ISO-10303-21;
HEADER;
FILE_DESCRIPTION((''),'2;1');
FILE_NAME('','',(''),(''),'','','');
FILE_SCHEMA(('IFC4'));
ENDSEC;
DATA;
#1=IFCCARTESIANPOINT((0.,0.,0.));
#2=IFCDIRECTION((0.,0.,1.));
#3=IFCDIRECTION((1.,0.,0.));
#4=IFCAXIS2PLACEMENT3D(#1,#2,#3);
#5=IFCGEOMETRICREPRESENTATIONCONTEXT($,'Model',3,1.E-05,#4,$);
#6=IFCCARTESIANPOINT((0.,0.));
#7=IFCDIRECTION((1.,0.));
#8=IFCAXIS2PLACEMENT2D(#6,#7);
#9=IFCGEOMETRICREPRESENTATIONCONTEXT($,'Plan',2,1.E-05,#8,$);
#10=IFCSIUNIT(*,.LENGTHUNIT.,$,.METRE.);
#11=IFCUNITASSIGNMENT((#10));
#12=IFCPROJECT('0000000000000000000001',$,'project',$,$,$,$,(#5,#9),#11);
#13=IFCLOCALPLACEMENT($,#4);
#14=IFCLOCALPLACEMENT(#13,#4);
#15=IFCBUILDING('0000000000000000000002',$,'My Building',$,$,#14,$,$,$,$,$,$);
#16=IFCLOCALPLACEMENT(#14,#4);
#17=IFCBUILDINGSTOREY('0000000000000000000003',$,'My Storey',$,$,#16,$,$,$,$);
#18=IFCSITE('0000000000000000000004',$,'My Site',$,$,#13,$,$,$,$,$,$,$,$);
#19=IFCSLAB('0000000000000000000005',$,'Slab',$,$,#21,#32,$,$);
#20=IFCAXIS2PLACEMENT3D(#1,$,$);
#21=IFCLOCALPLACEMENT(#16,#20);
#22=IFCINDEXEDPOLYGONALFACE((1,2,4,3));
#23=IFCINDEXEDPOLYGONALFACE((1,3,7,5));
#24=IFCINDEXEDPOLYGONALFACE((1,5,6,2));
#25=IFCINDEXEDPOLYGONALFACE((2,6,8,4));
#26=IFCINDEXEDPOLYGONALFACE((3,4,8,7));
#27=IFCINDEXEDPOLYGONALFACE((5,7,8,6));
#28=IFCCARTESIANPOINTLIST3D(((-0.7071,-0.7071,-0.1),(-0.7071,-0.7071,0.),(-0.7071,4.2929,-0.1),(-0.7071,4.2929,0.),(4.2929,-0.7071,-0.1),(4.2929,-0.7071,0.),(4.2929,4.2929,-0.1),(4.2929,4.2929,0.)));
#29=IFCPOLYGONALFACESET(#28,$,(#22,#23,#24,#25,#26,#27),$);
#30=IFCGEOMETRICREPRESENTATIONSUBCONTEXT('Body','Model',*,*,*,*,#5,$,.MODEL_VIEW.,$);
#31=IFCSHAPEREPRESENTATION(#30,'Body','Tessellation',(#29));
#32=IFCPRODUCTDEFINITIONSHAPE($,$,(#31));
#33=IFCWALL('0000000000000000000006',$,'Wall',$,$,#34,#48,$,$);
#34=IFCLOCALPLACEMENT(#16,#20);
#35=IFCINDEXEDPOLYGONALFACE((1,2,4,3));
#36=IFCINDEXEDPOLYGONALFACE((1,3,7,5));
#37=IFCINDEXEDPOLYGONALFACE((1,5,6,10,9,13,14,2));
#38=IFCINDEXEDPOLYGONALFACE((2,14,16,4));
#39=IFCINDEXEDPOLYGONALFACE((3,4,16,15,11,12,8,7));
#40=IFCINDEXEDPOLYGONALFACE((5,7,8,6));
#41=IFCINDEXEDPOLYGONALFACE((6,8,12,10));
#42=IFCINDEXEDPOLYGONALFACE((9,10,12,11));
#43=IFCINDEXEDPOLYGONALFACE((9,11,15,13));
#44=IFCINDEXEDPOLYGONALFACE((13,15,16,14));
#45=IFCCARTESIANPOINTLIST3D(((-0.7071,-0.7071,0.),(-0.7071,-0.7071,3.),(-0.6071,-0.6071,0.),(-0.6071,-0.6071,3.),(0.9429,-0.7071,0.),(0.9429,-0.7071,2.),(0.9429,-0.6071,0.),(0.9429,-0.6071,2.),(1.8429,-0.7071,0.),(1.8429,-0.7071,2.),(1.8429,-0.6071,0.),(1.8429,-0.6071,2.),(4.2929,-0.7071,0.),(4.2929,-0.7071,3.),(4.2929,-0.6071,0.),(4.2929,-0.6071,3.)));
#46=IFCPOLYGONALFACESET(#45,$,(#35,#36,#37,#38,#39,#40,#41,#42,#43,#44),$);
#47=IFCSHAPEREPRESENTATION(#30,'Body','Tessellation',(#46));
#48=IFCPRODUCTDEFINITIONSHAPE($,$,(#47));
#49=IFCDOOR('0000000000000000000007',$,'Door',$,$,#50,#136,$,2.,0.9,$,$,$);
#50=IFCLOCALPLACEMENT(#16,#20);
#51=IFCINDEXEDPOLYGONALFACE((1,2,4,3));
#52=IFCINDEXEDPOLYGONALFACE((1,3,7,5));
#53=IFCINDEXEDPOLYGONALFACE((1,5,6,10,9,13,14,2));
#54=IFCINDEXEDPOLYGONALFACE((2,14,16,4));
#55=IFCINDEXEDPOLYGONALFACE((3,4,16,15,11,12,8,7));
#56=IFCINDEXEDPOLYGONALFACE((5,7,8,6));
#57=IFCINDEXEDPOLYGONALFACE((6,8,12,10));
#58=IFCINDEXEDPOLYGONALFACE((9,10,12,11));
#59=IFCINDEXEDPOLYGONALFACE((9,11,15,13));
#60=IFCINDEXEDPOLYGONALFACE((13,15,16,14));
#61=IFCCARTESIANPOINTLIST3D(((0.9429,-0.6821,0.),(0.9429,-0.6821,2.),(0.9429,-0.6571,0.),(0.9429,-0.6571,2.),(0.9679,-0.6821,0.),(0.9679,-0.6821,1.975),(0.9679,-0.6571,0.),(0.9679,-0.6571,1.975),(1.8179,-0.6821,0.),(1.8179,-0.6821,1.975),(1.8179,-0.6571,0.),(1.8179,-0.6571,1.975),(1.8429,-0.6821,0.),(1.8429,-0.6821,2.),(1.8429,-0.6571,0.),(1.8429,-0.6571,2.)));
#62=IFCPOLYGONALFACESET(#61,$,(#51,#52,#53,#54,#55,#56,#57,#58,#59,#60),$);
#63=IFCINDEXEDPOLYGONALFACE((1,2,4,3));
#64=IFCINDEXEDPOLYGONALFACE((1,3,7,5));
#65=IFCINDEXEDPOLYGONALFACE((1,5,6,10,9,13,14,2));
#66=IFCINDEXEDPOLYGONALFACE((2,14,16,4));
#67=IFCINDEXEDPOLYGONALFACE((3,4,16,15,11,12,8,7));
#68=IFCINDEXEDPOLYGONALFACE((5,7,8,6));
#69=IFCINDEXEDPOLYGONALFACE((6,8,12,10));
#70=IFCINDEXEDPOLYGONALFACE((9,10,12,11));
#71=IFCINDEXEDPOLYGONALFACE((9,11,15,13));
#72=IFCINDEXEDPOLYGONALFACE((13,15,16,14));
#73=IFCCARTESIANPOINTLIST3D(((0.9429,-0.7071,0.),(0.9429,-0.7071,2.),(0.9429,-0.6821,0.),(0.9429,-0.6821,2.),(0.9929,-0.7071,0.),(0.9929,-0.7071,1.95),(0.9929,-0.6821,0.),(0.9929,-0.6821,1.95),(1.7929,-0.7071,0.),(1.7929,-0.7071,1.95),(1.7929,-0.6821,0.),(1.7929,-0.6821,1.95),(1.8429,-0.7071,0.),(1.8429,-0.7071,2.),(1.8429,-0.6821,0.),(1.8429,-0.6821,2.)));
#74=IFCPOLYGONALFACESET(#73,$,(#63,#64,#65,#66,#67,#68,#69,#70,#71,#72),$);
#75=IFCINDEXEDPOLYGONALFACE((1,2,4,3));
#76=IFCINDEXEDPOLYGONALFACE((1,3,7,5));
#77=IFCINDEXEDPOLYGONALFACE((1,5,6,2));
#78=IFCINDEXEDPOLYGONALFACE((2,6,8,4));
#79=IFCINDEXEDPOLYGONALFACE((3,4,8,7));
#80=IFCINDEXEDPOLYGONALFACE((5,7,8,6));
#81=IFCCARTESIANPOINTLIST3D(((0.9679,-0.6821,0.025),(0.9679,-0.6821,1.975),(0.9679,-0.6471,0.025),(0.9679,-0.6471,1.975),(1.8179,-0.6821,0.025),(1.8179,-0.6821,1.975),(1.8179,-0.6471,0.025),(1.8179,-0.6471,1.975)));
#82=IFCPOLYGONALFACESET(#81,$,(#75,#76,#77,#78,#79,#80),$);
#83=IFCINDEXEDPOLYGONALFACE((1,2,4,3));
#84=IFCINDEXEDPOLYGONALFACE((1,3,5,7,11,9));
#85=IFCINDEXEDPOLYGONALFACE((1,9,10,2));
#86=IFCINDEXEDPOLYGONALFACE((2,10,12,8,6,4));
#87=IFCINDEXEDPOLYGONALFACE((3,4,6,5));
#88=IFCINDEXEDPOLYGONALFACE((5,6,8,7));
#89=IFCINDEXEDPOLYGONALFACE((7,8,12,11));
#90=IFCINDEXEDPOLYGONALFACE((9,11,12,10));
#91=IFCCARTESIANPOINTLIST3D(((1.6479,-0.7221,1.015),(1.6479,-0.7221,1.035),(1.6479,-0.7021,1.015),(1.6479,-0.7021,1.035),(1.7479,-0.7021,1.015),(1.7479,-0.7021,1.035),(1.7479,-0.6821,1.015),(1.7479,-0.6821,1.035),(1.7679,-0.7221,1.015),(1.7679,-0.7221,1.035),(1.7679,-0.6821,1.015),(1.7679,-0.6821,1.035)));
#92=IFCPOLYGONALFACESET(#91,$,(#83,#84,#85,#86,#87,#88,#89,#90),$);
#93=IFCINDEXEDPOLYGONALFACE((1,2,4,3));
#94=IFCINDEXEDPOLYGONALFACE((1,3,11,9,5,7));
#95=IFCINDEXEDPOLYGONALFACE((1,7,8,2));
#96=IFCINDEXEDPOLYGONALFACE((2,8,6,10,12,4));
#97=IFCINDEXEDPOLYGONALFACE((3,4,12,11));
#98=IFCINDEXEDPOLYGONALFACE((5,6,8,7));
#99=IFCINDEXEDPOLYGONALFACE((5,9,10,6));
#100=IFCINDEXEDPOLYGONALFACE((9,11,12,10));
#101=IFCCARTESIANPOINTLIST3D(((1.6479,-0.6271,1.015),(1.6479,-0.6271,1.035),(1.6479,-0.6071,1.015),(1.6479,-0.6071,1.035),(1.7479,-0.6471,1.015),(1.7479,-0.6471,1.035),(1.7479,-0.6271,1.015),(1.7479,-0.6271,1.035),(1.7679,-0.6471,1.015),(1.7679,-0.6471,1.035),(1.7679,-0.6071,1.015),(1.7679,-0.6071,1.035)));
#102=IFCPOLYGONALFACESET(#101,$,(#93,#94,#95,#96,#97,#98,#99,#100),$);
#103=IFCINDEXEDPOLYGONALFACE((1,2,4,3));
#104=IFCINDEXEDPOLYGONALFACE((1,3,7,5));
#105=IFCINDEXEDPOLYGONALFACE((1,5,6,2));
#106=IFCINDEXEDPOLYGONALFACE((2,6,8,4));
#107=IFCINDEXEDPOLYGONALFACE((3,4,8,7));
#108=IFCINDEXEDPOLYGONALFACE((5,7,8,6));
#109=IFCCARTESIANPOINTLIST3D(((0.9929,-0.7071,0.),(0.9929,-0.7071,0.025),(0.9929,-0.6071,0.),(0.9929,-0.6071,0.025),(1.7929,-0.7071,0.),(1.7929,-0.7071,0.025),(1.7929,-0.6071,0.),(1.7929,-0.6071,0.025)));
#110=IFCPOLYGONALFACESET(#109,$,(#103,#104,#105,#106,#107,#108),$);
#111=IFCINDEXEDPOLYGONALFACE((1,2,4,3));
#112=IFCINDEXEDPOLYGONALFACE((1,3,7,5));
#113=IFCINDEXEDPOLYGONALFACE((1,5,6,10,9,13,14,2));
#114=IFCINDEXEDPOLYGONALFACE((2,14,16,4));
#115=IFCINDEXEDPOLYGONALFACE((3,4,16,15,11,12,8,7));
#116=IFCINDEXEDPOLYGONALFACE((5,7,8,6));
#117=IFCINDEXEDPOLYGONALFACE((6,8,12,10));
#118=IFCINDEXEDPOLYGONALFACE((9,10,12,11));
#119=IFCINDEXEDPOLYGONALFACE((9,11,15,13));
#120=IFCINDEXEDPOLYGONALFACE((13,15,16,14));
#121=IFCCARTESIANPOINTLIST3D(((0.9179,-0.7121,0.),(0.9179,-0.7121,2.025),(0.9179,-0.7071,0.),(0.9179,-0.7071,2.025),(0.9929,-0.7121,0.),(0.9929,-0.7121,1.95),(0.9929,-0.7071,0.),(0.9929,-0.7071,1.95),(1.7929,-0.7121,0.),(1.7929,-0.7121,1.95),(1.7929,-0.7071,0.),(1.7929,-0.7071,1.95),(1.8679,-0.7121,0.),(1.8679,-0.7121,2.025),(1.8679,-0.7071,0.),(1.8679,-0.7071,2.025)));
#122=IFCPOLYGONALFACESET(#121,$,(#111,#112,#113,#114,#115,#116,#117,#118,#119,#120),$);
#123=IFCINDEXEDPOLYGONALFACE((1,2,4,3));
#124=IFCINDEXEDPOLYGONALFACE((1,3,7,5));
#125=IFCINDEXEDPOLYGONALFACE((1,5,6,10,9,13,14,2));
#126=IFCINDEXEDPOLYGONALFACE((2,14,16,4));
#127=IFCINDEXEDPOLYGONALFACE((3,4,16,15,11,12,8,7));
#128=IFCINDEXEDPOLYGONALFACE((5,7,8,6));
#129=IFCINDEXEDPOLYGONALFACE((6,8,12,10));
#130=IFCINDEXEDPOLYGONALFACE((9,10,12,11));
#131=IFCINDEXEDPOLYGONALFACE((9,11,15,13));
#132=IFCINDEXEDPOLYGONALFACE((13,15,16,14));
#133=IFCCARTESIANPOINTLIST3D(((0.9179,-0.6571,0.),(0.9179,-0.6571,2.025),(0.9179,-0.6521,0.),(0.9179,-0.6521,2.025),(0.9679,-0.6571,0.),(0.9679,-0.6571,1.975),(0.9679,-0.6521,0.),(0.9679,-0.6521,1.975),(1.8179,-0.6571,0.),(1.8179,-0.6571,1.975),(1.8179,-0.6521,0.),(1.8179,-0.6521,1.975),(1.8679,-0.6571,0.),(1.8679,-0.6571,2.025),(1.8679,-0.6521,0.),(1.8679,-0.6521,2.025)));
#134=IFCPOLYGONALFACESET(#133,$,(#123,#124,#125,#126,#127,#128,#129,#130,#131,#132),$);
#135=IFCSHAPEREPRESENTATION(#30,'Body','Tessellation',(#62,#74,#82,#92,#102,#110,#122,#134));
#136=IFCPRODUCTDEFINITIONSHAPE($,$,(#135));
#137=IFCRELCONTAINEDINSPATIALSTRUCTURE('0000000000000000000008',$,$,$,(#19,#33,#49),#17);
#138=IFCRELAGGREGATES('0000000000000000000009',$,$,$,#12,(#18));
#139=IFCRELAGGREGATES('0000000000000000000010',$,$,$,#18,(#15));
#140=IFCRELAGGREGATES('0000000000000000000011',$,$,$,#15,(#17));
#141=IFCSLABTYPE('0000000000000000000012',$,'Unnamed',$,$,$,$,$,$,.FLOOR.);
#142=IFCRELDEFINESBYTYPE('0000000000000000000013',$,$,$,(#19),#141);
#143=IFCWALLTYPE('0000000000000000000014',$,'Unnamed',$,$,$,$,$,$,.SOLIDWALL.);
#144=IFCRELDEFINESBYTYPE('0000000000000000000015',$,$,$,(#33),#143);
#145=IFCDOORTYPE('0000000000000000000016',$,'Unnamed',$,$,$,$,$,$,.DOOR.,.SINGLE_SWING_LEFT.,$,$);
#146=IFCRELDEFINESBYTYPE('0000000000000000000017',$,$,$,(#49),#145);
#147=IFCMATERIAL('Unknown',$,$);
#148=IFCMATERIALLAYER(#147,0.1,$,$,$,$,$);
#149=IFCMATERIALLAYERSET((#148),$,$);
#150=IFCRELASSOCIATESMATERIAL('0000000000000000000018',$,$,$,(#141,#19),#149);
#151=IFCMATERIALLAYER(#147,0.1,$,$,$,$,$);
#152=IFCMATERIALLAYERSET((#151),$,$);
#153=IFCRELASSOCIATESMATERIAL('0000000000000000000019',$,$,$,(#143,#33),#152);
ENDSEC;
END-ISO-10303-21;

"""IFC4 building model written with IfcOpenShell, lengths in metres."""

from ifc_helpers import new_model, entity, si_unit, frame, origin_with_axes, origin_2d_with_axis, place, context, subcontext, project, spatial, line, indexed_curve, outline, extrude, shape, source, transform, mapped, material, layer, layer_set, layer_usage, type_object, type_shapes, element, fill, save


model = new_model("IFC4")

# Units and contexts
model_context = context("Model", 3, precision=1e-05, world=origin_with_axes())
plan_context = context("Plan", 2, precision=1e-05, world=origin_2d_with_axis())
body_context_1 = subcontext(model_context, "Body", "Model", "MODEL_VIEW")
body_context_2 = subcontext(plan_context, "Body", "Plan", "PLAN_VIEW")
ifc_project = project(units=[si_unit("LENGTHUNIT", "METRE")], contexts=[model_context, plan_context])

# Site, building, storey
site_placement = place(None, origin_with_axes())
site = spatial("IfcSite", under=ifc_project, at=site_placement, Name="My Site")
building_placement = place(site_placement, origin_with_axes())
building = spatial("IfcBuilding", under=site, at=building_placement, Name="My Building")
storey_placement = place(building_placement, origin_with_axes())
storey = spatial("IfcBuildingStorey", under=building, at=storey_placement, Name="My Storey")

# Slab
ifc_material = material(Name="Unknown")
ifc_layer_1 = layer(ifc_material, 0.1)
ifc_layer_set_1 = layer_set([ifc_layer_1])
ifc_layer_usage_1 = layer_usage(ifc_layer_set_1, "AXIS3", "POSITIVE", -0.1)
slab_type = type_object("IfcSlabType", Name="Unnamed", PredefinedType="FLOOR", material=ifc_layer_set_1)
slab_placement = place(storey_placement, frame((-0.7071, -0.7071, 0.0), z_axis=(0.0, 0.0, 1.0), x_axis=(1.0, 0.0, 0.0)))
element("IfcSlab", 1, at=slab_placement, inside=storey, type_object=slab_type, material=ifc_layer_usage_1, Name="Slab", context=body_context_1, shape_type="SweptSolid", body=[
    extrude(outline(indexed_curve([(0.0, 0.0), (5.0, 0.0), (5.0, 5.0), (0.0, 5.0), (0.0, 0.0)])), frame((0.0, 0.0, -0.1), z_axis=(0.0, 0.0, 1.0), x_axis=(1.0, 0.0, 0.0)), (0.0, 0.0, 1.0), 0.1),
])

# Wall, opening, door
ifc_layer_2 = layer(ifc_material, 0.1)
ifc_layer_set_2 = layer_set([ifc_layer_2])
ifc_layer_usage_2 = layer_usage(ifc_layer_set_2, "AXIS2", "POSITIVE", 0.0)
wall_type = type_object("IfcWallType", Name="Unnamed", PredefinedType="SOLIDWALL", material=ifc_layer_set_2)
wall_1_placement = place(storey_placement, frame((-0.7071, -0.7071, 0.0), z_axis=(0.0, 0.0, 1.0), x_axis=(1.0, 0.0, 0.0)))
wall_1 = element("IfcWall", 2, at=wall_1_placement, inside=storey, type_object=wall_type, material=ifc_layer_usage_2, Name="Wall", context=body_context_1, shape_type="SweptSolid", body=[
    extrude(outline(indexed_curve([(0.0, 0.0), (0.1, 0.1), (5.0, 0.1), (5.0, 0.0)], segments=[line(1, 2, 3, 4, 1)])), origin_with_axes(), (0.0, 0.0, 1.0), 3.0),
])
shared_shape_1 = source(origin_with_axes(), body_context_1, "Body", "SweptSolid", [
    extrude(outline(indexed_curve([(0.0, 0.0), (0.9, 0.0), (0.9, 2.0), (0.0, 2.0)], segments=[line(1, 2, 3, 4, 1)])), frame((0.0, -0.6, 0.0), z_axis=(0.0, -1.0, 0.0), x_axis=(1.0, 0.0, 0.0)), (0.0, 0.0, -1.0), 1.2),
])
opening_1_placement = place(wall_1_placement, frame((1.65, 0.0, 0.0), z_axis=(0.0, 0.0, 1.0), x_axis=(1.0, 0.0, 0.0)))
opening_1 = element("IfcOpeningElement", 3, at=opening_1_placement, cuts=wall_1, PredefinedType="OPENING", context=body_context_1, shape_type="MappedRepresentation", body=[
    mapped(shared_shape_1, transform((0.0, 0.0, 0.0), x_axis=(1.0, 0.0, 0.0), y_axis=(0.0, 1.0, 0.0), z_axis=(0.0, 0.0, 1.0), scale=1.0)),
])
door_type = type_object("IfcDoorType", Name="Unnamed", OperationType="SINGLE_SWING_LEFT", PredefinedType="DOOR")
shared_shape_2 = source(origin_with_axes(), body_context_1, "Body", "SweptSolid", [
    extrude(outline(indexed_curve([(0.0, 0.0), (0.0, 2.0), (0.9, 2.0), (0.9, 0.0), (0.875, 0.0), (0.875, 1.975), (0.025, 1.975), (0.025, 0.0)], segments=[line(1, 2, 3, 4, 5, 6, 7, 8, 1)])), frame((0.0, 0.025, 0.0), z_axis=(0.0, -1.0, 0.0), x_axis=(1.0, 0.0, 0.0)), (0.0, 0.0, -1.0), 0.025),
    extrude(outline(indexed_curve([(0.0, 0.0), (0.0, 2.0), (0.9, 2.0), (0.9, 0.0), (0.85, 0.0), (0.85, 1.95), (0.05, 1.95), (0.05, 0.0)], segments=[line(1, 2, 3, 4, 5, 6, 7, 8, 1)])), frame((0.0, 0.0, 0.0), z_axis=(0.0, -1.0, 0.0), x_axis=(1.0, 0.0, 0.0)), (0.0, 0.0, -1.0), 0.025),
    extrude(outline(indexed_curve([(0.0, 0.0), (0.85, 0.0), (0.85, 0.035), (0.0, 0.035)], segments=[line(1, 2, 3, 4, 1)])), frame((0.025, 0.025, 0.025), z_axis=(0.0, 0.0, 1.0), x_axis=(1.0, 0.0, 0.0)), (0.0, 0.0, 1.0), 1.95),
    extrude(outline(indexed_curve([(0.0, 0.0), (0.0, -0.04), (-0.12, -0.04), (-0.12, -0.02), (-0.02, -0.02), (-0.02, 0.0)], segments=[line(1, 2, 3, 4, 5, 6, 1)])), frame((0.825, 0.025, 1.015), z_axis=(0.0, 0.0, 1.0), x_axis=(1.0, 0.0, 0.0)), (0.0, 0.0, 1.0), 0.02),
    extrude(outline(indexed_curve([(0.0, 0.0), (0.0, 0.04), (-0.12, 0.04), (-0.12, 0.02), (-0.02, 0.02), (-0.02, 0.0)], segments=[line(1, 2, 3, 4, 5, 6, 1)])), frame((0.825, 0.06, 1.015), z_axis=(0.0, 0.0, 1.0), x_axis=(1.0, 0.0, 0.0)), (0.0, 0.0, 1.0), 0.02),
    extrude(outline(indexed_curve([(0.0, 0.0), (0.8, 0.0), (0.8, 0.1), (0.0, 0.1)], segments=[line(1, 2, 3, 4, 1)])), frame((0.05, 0.0, 0.0), z_axis=(0.0, 0.0, 1.0), x_axis=(1.0, 0.0, 0.0)), (0.0, 0.0, 1.0), 0.025),
    extrude(outline(indexed_curve([(0.0, 0.0), (0.0, 2.025), (0.95, 2.025), (0.95, 0.0), (0.875, 0.0), (0.875, 1.95), (0.075, 1.95), (0.075, 0.0)], segments=[line(1, 2, 3, 4, 5, 6, 7, 8, 1)])), frame((-0.025, -0.005, 0.0), z_axis=(0.0, -1.0, 0.0), x_axis=(1.0, 0.0, 0.0)), (0.0, 0.0, -1.0), 0.005),
    extrude(outline(indexed_curve([(0.0, 0.0), (0.0, 2.025), (0.95, 2.025), (0.95, 0.0), (0.9, 0.0), (0.9, 1.975), (0.05, 1.975), (0.05, 0.0)], segments=[line(1, 2, 3, 4, 5, 6, 7, 8, 1)])), frame((-0.025, 0.05, 0.0), z_axis=(0.0, -1.0, 0.0), x_axis=(1.0, 0.0, 0.0)), (0.0, 0.0, -1.0), 0.005),
])
shared_shape_3 = source(origin_with_axes(), body_context_2, "Body", "Curve2D", [
    entity("IfcIndexedPolyCurve", entity("IfcCartesianPointList2D", [[0.0, 0.0], [0.0, 0.05], [0.025, 0.05], [0.025, 0.025], [0.05, 0.025], [0.05, 0.0]]), [entity("IfcLineIndex", [1, 2, 3, 4, 5, 6, 1])]),
    entity("IfcIndexedPolyCurve", entity("IfcCartesianPointList2D", [[0.9, 0.0], [0.9, 0.05], [0.875, 0.05], [0.875, 0.025], [0.85, 0.025], [0.85, 0.0]]), [entity("IfcLineIndex", [1, 2, 3, 4, 5, 6, 1])]),
    entity("IfcTrimmedCurve", entity("IfcEllipse", entity("IfcAxis2Placement2D", entity("IfcCartesianPoint", [0.06, 0.05]), entity("IfcDirection", [1.0, 0.0])), 0.815, 0.85), [entity("IfcCartesianPoint", [0.875, 0.05])], [entity("IfcCartesianPoint", [0.06, 0.9])], True, "CARTESIAN"),
    entity("IfcIndexedPolyCurve", entity("IfcCartesianPointList2D", [[0.025, 0.05], [0.06, 0.05], [0.06, 0.9], [0.025, 0.9]]), [entity("IfcLineIndex", [1, 2, 3, 4, 1])]),
])
type_shapes(door_type, [shared_shape_2, shared_shape_3])
door_placement = place(opening_1_placement, frame((0.0, 0.0, 0.0), z_axis=(0.0, 0.0, 1.0), x_axis=(1.0, 0.0, 0.0)))
door = element("IfcDoor", 4, at=door_placement, inside=storey, type_object=door_type, Name="Door", OverallHeight=2.0, OverallWidth=0.9, shapes=[
    shape(body_context_1, "Body", "MappedRepresentation", [mapped(shared_shape_2, transform((0.0, 0.0, 0.0), x_axis=(1.0, 0.0, 0.0), y_axis=(0.0, 1.0, 0.0), z_axis=(0.0, 0.0, 1.0), scale=1.0))]),
    shape(body_context_2, "Body", "MappedRepresentation", [mapped(shared_shape_3, transform((0.0, 0.0, 0.0), x_axis=(1.0, 0.0, 0.0), y_axis=(0.0, 1.0, 0.0), z_axis=(0.0, 0.0, 1.0), scale=1.0))]),
])
fill(opening_1, door)

save(model, "model.ifc")
